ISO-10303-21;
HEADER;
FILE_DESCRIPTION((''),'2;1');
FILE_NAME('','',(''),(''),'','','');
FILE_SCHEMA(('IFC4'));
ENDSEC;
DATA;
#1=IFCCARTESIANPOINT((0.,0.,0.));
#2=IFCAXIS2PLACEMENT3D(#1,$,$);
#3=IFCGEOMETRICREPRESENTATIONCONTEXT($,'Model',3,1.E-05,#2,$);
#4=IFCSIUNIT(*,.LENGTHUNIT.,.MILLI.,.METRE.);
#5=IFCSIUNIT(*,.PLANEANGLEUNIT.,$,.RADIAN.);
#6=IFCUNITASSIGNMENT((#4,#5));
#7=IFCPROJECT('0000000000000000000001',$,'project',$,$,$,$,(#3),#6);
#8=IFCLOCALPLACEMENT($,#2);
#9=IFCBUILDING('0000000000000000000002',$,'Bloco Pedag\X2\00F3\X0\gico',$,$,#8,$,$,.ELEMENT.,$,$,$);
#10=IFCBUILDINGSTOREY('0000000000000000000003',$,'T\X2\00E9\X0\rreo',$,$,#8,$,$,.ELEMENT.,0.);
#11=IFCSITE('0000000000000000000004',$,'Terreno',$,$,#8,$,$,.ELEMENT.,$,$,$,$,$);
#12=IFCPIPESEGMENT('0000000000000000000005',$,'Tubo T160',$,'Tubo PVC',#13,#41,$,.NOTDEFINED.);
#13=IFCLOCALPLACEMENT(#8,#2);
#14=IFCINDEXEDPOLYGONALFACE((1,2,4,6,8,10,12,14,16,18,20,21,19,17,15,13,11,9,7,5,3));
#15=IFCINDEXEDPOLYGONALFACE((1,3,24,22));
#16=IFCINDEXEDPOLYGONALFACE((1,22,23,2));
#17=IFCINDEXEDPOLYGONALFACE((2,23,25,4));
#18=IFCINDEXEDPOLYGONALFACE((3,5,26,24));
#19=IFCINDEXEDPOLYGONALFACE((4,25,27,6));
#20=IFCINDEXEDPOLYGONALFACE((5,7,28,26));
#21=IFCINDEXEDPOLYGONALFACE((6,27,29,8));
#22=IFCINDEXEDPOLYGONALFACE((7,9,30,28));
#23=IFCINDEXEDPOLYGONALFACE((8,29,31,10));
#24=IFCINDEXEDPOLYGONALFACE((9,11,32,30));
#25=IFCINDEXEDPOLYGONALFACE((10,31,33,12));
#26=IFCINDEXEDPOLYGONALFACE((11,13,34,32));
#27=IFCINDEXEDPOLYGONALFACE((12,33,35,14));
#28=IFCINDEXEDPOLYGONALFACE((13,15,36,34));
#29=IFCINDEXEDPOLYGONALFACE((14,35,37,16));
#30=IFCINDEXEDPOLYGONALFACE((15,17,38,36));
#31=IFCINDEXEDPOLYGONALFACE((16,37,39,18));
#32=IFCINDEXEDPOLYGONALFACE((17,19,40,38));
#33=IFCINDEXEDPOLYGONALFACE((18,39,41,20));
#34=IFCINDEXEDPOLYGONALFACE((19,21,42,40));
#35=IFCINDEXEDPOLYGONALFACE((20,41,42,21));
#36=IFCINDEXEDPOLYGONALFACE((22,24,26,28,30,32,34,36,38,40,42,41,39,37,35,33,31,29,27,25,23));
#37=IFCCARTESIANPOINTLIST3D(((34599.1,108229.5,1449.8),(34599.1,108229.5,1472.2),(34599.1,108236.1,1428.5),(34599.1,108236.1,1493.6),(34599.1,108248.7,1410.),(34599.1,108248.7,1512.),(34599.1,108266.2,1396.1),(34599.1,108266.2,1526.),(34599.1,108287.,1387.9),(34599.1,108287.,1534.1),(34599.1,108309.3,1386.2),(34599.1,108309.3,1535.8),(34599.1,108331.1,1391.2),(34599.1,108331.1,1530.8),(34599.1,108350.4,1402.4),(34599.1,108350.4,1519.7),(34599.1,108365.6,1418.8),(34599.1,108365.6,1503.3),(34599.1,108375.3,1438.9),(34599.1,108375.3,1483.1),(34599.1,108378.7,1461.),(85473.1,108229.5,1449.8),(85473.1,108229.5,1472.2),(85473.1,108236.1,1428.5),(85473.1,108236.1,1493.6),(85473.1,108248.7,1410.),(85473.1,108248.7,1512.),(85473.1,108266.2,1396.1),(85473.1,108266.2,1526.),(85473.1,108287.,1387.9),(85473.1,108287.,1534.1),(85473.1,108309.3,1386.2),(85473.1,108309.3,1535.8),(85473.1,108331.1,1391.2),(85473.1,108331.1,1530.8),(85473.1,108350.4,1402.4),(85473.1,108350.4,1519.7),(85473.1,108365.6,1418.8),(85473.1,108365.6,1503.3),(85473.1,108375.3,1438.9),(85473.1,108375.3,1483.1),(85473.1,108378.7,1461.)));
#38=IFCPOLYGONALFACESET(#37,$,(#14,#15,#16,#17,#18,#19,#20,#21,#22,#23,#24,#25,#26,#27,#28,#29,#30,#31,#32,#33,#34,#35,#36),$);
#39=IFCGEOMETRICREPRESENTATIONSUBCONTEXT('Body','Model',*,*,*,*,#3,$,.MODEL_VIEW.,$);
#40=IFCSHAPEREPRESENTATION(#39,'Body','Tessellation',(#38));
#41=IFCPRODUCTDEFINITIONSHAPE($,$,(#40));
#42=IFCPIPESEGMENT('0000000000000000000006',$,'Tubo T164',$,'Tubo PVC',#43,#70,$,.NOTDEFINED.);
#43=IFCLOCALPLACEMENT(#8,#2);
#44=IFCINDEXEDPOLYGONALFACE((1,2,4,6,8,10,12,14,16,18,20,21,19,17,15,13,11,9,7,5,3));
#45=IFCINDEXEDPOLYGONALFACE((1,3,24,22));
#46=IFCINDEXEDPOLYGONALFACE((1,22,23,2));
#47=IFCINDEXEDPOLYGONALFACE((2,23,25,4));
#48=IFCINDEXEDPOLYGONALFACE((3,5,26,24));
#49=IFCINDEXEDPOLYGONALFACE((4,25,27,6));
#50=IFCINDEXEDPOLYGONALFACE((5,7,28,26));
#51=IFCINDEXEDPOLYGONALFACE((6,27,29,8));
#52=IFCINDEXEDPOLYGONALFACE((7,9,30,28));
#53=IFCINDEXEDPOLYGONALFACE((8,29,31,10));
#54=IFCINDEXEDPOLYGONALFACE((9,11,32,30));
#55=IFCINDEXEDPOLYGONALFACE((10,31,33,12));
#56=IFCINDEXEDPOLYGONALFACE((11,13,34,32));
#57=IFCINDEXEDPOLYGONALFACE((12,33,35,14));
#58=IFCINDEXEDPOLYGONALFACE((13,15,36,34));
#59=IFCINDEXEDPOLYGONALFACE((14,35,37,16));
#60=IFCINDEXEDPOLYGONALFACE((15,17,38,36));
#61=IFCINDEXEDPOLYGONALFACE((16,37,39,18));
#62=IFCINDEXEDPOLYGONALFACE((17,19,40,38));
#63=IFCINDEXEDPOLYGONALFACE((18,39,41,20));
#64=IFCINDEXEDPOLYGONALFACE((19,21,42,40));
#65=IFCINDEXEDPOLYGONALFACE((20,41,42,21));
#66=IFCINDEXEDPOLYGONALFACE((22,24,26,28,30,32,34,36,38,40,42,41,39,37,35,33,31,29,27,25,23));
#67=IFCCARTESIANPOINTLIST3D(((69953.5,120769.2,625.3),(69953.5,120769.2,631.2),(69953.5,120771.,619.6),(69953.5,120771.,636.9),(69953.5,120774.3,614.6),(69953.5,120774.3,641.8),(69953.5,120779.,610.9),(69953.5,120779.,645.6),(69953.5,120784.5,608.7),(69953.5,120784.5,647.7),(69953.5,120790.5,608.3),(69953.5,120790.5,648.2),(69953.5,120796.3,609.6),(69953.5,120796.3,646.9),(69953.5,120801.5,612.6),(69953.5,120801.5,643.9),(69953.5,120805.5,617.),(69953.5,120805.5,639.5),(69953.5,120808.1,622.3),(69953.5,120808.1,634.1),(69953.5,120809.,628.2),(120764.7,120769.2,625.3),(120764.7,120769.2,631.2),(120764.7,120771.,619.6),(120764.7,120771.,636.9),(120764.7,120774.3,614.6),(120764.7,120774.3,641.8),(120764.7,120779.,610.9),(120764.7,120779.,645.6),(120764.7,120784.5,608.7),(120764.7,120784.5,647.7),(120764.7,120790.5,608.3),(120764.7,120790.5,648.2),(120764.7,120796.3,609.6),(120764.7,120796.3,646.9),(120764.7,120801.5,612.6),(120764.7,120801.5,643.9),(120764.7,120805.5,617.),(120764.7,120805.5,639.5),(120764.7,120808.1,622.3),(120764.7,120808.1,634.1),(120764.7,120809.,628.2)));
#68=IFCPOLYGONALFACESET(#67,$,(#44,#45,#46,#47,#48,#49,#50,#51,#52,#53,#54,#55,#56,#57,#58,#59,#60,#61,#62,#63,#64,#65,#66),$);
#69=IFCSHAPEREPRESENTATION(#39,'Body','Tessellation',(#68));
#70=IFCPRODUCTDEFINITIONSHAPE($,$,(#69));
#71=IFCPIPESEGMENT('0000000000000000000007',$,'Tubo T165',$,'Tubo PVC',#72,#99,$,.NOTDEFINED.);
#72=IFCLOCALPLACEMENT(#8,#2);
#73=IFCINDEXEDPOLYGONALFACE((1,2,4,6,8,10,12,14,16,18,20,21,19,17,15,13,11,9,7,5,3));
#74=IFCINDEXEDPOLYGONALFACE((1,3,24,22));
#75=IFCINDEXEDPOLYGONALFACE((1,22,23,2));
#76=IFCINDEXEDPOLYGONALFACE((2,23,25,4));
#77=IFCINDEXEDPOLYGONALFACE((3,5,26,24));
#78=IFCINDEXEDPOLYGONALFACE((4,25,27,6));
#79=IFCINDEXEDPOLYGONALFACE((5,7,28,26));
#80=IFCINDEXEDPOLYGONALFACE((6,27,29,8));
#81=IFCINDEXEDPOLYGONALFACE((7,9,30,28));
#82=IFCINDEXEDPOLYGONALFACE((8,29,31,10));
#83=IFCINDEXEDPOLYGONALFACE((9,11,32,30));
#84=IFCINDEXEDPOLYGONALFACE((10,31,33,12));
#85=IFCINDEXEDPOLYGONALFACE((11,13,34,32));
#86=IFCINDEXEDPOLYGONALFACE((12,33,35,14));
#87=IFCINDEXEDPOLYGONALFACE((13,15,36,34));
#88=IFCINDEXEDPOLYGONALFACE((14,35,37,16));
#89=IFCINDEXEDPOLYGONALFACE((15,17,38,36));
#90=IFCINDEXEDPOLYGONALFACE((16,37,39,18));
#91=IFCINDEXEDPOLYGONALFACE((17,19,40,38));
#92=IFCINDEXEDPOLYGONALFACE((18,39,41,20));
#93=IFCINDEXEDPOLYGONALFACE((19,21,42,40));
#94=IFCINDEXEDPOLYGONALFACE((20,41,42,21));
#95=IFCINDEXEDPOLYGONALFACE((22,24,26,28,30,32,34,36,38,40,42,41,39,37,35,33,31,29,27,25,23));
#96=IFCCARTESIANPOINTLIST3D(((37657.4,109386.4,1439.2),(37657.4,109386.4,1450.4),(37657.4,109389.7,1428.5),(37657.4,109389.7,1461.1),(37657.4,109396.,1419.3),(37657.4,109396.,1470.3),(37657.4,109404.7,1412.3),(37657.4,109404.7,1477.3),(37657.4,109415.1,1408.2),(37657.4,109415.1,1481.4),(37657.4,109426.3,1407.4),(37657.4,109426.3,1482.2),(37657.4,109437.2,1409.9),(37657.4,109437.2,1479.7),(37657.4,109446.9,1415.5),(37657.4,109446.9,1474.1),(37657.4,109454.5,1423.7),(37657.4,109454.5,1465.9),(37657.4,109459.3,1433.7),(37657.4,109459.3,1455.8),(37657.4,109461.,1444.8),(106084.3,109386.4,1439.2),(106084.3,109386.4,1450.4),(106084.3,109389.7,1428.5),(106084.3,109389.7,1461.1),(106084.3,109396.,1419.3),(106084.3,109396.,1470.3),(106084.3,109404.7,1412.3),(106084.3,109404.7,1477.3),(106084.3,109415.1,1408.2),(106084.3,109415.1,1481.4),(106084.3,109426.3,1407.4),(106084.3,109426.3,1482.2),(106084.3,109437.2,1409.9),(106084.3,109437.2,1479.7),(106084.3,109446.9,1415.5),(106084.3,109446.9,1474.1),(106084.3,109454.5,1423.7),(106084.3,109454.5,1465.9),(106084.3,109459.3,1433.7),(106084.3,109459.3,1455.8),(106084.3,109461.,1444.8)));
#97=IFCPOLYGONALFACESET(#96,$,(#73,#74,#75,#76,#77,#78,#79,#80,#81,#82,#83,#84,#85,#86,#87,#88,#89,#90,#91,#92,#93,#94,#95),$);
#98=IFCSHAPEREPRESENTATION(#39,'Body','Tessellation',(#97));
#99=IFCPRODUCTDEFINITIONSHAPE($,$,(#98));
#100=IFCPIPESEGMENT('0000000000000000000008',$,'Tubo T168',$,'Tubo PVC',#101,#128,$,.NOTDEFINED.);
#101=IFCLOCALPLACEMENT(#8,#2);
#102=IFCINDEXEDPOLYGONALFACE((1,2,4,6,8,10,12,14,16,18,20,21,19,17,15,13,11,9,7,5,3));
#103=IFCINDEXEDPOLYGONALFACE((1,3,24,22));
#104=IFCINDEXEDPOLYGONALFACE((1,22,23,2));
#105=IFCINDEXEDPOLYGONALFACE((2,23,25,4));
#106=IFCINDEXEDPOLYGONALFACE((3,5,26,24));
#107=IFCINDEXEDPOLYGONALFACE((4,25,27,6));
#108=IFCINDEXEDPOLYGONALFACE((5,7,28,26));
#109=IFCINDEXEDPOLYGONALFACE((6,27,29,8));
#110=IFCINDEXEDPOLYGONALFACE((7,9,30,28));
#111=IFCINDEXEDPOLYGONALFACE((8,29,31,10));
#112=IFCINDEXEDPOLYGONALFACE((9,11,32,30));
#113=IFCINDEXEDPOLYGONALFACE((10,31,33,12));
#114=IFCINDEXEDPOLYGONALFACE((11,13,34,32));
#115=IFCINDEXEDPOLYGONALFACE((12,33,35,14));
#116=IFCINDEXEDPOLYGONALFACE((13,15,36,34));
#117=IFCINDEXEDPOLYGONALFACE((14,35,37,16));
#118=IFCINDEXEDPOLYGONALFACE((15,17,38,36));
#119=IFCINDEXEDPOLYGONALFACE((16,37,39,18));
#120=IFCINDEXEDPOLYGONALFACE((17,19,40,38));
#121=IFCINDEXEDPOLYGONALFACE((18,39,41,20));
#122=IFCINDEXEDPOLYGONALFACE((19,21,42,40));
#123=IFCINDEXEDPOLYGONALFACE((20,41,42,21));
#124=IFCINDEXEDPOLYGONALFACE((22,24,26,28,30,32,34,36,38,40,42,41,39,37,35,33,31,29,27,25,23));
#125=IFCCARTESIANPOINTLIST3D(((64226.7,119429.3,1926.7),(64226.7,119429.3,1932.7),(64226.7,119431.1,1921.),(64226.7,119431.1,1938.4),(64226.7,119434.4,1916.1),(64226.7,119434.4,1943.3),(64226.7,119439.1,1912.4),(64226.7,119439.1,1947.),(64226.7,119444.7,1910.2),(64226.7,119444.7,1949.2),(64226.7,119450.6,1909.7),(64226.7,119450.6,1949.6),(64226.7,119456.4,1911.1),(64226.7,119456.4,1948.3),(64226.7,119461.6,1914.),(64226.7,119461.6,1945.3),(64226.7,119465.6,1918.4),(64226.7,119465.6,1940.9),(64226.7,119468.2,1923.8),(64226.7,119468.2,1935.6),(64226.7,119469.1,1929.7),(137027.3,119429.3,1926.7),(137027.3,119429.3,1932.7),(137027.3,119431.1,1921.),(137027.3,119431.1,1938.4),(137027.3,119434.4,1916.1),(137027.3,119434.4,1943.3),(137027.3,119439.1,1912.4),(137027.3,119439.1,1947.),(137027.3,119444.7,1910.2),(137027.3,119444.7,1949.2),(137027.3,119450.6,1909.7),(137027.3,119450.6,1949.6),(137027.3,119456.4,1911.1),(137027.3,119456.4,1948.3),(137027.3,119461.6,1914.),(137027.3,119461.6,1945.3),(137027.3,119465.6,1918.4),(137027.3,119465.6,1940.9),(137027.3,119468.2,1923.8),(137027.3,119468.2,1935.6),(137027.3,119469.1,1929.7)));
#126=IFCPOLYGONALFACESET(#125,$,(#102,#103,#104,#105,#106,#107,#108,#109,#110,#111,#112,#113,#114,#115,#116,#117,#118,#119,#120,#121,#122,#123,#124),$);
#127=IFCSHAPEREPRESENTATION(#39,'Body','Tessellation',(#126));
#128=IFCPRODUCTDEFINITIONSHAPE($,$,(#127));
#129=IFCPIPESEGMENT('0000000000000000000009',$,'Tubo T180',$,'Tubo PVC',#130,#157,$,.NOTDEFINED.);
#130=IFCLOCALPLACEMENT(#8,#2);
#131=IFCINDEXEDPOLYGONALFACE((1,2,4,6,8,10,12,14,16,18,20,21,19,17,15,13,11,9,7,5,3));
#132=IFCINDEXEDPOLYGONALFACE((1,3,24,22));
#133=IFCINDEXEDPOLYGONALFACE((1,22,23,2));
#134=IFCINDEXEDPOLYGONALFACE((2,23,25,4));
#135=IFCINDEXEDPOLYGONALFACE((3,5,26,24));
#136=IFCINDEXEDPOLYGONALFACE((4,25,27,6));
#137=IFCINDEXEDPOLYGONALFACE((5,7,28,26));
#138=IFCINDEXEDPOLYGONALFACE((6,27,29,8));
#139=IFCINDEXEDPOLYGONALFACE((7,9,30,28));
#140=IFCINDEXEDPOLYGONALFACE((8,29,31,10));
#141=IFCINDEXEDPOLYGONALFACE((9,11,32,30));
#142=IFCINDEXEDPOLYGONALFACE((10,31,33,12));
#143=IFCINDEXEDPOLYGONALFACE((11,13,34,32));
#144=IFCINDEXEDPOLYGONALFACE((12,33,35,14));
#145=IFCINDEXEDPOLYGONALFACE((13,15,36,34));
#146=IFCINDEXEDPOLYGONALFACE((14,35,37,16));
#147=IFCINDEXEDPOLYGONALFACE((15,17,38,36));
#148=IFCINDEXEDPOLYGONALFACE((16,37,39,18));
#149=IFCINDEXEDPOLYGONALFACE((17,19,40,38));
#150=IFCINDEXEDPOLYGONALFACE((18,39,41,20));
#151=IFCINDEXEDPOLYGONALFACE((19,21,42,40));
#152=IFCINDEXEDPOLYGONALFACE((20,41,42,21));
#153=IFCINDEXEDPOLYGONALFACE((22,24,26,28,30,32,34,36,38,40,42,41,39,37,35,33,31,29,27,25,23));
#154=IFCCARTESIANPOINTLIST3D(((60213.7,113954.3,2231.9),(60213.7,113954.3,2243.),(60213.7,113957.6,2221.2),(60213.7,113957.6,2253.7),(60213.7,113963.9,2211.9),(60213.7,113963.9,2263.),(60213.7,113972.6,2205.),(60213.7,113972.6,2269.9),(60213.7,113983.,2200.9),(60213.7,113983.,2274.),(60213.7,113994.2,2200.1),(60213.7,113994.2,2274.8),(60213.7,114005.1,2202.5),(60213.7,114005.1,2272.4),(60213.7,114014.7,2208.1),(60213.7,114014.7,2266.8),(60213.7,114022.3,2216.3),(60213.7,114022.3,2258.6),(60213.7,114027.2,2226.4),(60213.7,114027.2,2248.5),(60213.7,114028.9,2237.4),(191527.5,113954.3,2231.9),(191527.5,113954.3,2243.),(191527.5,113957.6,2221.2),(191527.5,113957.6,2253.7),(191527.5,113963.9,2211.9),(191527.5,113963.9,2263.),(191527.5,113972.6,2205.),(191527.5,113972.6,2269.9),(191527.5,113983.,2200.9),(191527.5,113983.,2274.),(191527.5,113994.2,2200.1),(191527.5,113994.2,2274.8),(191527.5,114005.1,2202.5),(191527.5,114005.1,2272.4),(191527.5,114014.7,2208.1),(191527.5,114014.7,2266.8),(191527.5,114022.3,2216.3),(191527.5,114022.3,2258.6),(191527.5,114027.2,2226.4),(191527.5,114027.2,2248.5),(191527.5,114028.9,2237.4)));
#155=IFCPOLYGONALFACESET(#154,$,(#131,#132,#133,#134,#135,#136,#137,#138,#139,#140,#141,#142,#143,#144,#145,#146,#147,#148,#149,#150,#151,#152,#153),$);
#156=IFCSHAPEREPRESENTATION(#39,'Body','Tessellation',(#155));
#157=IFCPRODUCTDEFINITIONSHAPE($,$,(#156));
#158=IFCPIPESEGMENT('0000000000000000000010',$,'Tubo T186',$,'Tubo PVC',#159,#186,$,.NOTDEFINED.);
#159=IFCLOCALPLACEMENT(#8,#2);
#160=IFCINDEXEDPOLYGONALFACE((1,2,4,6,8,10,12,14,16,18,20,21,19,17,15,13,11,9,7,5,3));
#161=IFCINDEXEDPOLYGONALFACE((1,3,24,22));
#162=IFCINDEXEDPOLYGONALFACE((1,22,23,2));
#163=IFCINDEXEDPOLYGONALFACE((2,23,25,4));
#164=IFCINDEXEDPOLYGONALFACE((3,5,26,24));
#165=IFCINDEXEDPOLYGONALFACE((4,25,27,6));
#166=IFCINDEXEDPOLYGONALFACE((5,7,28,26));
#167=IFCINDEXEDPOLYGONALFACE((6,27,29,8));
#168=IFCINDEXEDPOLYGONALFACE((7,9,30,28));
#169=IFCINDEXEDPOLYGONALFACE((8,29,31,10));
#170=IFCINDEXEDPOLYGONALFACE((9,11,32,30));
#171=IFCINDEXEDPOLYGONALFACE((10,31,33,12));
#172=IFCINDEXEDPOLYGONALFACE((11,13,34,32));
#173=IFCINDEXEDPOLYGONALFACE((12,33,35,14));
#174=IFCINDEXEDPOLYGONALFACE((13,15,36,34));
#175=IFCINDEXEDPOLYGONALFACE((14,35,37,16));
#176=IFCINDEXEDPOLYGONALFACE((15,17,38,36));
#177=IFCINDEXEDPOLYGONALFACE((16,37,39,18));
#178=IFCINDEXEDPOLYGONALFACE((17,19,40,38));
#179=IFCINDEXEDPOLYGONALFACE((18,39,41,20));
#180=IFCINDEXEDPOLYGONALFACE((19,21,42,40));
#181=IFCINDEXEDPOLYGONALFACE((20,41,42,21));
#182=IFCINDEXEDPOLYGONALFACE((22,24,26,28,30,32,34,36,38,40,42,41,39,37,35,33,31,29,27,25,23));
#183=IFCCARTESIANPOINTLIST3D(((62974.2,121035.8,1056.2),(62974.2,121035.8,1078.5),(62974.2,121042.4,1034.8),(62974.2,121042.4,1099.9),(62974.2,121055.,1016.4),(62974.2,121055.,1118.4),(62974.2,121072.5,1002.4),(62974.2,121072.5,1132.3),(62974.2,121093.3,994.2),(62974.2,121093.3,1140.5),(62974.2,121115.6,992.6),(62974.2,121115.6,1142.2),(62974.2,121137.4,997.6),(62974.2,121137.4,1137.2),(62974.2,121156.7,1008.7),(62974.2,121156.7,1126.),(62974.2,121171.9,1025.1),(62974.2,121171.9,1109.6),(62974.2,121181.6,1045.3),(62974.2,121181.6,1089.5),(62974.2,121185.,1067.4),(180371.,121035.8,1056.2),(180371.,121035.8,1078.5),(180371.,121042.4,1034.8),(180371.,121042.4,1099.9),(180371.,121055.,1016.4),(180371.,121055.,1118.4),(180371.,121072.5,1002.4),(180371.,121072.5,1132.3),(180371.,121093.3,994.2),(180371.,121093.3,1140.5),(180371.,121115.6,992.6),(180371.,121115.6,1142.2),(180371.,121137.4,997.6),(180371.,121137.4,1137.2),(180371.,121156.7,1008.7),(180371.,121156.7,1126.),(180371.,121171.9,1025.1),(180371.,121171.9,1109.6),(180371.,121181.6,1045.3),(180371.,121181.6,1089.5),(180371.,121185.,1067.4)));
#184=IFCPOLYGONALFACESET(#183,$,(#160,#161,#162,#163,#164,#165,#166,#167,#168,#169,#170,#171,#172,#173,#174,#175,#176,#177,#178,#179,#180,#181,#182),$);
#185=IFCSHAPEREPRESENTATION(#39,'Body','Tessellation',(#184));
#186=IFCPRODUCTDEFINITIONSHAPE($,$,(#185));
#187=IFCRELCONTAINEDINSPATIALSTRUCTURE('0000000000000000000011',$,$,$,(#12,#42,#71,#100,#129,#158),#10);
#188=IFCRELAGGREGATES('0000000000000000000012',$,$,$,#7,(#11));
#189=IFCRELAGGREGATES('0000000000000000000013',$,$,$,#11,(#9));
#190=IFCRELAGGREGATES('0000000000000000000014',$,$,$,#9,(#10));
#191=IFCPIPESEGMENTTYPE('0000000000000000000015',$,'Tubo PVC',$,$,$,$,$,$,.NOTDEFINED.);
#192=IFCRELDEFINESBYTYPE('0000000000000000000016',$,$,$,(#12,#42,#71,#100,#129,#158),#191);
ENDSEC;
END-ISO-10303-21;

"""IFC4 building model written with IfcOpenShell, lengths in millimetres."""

from ifc_helpers import new_model, si_unit, frame, origin, origin_2d, place, context, subcontext, project, spatial, circle, extrude, type_object, element, save


model = new_model("IFC4")

# Units and contexts
model_context = context("Model", 3, precision=1e-05, world=origin())
body_context = subcontext(model_context, "Body", "Model", "MODEL_VIEW")
ifc_project = project(units=[si_unit("LENGTHUNIT", "METRE", prefix="MILLI"), si_unit("PLANEANGLEUNIT", "RADIAN")], contexts=[model_context])

# Site, building, storey
placement = place(None, origin())
site = spatial("IfcSite", under=ifc_project, at=placement, Name="Terreno", CompositionType="ELEMENT")
building = spatial("IfcBuilding", under=site, at=placement, Name="Bloco Pedagógico", CompositionType="ELEMENT")
storey = spatial("IfcBuildingStorey", under=building, at=placement, Name="Térreo", CompositionType="ELEMENT", Elevation=0.0)

# Pipe segments
pipe_segment_type = type_object("IfcPipeSegmentType", Name="Tubo PVC", PredefinedType="NOTDEFINED")
pipe_segment_1_placement = place(None, frame((34599.1, 108303.7, 1461.0), z_axis=(1.0, 0.0, 0.0), x_axis=(0.0, 1.0, 0.0)))
element("IfcPipeSegment", 1, at=pipe_segment_1_placement, inside=storey, type_object=pipe_segment_type, Name="Tubo T160", ObjectType="Tubo PVC", PredefinedType="NOTDEFINED", context=body_context, shape_type="SweptSolid", body=[
    extrude(circle(Radius=75.0, at=origin_2d()), None, (0.0, 0.0, 1.0), 50874.0),
])
pipe_segment_2_placement = place(None, frame((69953.5, 120789.0, 628.2), z_axis=(1.0, 0.0, 0.0), x_axis=(0.0, 1.0, 0.0)))
element("IfcPipeSegment", 2, at=pipe_segment_2_placement, inside=storey, type_object=pipe_segment_type, Name="Tubo T164", ObjectType="Tubo PVC", PredefinedType="NOTDEFINED", context=body_context, shape_type="SweptSolid", body=[
    extrude(circle(Radius=20.0, at=origin_2d()), None, (0.0, 0.0, 1.0), 50811.3),
])
pipe_segment_3_placement = place(None, frame((37657.4, 109423.5, 1444.8), z_axis=(1.0, 0.0, 0.0), x_axis=(0.0, 1.0, 0.0)))
element("IfcPipeSegment", 3, at=pipe_segment_3_placement, inside=storey, type_object=pipe_segment_type, Name="Tubo T165", ObjectType="Tubo PVC", PredefinedType="NOTDEFINED", context=body_context, shape_type="SweptSolid", body=[
    extrude(circle(Radius=37.5, at=origin_2d()), None, (0.0, 0.0, 1.0), 68426.9),
])
pipe_segment_4_placement = place(None, frame((64226.7, 119449.1, 1929.7), z_axis=(1.0, 0.0, 0.0), x_axis=(0.0, 1.0, 0.0)))
element("IfcPipeSegment", 4, at=pipe_segment_4_placement, inside=storey, type_object=pipe_segment_type, Name="Tubo T168", ObjectType="Tubo PVC", PredefinedType="NOTDEFINED", context=body_context, shape_type="SweptSolid", body=[
    extrude(circle(Radius=20.0, at=origin_2d()), None, (0.0, 0.0, 1.0), 72800.6),
])
pipe_segment_5_placement = place(None, frame((60213.7, 113991.4, 2237.4), z_axis=(1.0, 0.0, 0.0), x_axis=(0.0, 1.0, 0.0)))
element("IfcPipeSegment", 5, at=pipe_segment_5_placement, inside=storey, type_object=pipe_segment_type, Name="Tubo T180", ObjectType="Tubo PVC", PredefinedType="NOTDEFINED", context=body_context, shape_type="SweptSolid", body=[
    extrude(circle(Radius=37.5, at=origin_2d()), None, (0.0, 0.0, 1.0), 131313.8),
])
pipe_segment_6_placement = place(None, frame((62974.2, 121110.0, 1067.4), z_axis=(1.0, 0.0, 0.0), x_axis=(0.0, 1.0, 0.0)))
element("IfcPipeSegment", 6, at=pipe_segment_6_placement, inside=storey, type_object=pipe_segment_type, Name="Tubo T186", ObjectType="Tubo PVC", PredefinedType="NOTDEFINED", context=body_context, shape_type="SweptSolid", body=[
    extrude(circle(Radius=75.0, at=origin_2d()), None, (0.0, 0.0, 1.0), 117396.8),
])

save(model, "model.ifc")
